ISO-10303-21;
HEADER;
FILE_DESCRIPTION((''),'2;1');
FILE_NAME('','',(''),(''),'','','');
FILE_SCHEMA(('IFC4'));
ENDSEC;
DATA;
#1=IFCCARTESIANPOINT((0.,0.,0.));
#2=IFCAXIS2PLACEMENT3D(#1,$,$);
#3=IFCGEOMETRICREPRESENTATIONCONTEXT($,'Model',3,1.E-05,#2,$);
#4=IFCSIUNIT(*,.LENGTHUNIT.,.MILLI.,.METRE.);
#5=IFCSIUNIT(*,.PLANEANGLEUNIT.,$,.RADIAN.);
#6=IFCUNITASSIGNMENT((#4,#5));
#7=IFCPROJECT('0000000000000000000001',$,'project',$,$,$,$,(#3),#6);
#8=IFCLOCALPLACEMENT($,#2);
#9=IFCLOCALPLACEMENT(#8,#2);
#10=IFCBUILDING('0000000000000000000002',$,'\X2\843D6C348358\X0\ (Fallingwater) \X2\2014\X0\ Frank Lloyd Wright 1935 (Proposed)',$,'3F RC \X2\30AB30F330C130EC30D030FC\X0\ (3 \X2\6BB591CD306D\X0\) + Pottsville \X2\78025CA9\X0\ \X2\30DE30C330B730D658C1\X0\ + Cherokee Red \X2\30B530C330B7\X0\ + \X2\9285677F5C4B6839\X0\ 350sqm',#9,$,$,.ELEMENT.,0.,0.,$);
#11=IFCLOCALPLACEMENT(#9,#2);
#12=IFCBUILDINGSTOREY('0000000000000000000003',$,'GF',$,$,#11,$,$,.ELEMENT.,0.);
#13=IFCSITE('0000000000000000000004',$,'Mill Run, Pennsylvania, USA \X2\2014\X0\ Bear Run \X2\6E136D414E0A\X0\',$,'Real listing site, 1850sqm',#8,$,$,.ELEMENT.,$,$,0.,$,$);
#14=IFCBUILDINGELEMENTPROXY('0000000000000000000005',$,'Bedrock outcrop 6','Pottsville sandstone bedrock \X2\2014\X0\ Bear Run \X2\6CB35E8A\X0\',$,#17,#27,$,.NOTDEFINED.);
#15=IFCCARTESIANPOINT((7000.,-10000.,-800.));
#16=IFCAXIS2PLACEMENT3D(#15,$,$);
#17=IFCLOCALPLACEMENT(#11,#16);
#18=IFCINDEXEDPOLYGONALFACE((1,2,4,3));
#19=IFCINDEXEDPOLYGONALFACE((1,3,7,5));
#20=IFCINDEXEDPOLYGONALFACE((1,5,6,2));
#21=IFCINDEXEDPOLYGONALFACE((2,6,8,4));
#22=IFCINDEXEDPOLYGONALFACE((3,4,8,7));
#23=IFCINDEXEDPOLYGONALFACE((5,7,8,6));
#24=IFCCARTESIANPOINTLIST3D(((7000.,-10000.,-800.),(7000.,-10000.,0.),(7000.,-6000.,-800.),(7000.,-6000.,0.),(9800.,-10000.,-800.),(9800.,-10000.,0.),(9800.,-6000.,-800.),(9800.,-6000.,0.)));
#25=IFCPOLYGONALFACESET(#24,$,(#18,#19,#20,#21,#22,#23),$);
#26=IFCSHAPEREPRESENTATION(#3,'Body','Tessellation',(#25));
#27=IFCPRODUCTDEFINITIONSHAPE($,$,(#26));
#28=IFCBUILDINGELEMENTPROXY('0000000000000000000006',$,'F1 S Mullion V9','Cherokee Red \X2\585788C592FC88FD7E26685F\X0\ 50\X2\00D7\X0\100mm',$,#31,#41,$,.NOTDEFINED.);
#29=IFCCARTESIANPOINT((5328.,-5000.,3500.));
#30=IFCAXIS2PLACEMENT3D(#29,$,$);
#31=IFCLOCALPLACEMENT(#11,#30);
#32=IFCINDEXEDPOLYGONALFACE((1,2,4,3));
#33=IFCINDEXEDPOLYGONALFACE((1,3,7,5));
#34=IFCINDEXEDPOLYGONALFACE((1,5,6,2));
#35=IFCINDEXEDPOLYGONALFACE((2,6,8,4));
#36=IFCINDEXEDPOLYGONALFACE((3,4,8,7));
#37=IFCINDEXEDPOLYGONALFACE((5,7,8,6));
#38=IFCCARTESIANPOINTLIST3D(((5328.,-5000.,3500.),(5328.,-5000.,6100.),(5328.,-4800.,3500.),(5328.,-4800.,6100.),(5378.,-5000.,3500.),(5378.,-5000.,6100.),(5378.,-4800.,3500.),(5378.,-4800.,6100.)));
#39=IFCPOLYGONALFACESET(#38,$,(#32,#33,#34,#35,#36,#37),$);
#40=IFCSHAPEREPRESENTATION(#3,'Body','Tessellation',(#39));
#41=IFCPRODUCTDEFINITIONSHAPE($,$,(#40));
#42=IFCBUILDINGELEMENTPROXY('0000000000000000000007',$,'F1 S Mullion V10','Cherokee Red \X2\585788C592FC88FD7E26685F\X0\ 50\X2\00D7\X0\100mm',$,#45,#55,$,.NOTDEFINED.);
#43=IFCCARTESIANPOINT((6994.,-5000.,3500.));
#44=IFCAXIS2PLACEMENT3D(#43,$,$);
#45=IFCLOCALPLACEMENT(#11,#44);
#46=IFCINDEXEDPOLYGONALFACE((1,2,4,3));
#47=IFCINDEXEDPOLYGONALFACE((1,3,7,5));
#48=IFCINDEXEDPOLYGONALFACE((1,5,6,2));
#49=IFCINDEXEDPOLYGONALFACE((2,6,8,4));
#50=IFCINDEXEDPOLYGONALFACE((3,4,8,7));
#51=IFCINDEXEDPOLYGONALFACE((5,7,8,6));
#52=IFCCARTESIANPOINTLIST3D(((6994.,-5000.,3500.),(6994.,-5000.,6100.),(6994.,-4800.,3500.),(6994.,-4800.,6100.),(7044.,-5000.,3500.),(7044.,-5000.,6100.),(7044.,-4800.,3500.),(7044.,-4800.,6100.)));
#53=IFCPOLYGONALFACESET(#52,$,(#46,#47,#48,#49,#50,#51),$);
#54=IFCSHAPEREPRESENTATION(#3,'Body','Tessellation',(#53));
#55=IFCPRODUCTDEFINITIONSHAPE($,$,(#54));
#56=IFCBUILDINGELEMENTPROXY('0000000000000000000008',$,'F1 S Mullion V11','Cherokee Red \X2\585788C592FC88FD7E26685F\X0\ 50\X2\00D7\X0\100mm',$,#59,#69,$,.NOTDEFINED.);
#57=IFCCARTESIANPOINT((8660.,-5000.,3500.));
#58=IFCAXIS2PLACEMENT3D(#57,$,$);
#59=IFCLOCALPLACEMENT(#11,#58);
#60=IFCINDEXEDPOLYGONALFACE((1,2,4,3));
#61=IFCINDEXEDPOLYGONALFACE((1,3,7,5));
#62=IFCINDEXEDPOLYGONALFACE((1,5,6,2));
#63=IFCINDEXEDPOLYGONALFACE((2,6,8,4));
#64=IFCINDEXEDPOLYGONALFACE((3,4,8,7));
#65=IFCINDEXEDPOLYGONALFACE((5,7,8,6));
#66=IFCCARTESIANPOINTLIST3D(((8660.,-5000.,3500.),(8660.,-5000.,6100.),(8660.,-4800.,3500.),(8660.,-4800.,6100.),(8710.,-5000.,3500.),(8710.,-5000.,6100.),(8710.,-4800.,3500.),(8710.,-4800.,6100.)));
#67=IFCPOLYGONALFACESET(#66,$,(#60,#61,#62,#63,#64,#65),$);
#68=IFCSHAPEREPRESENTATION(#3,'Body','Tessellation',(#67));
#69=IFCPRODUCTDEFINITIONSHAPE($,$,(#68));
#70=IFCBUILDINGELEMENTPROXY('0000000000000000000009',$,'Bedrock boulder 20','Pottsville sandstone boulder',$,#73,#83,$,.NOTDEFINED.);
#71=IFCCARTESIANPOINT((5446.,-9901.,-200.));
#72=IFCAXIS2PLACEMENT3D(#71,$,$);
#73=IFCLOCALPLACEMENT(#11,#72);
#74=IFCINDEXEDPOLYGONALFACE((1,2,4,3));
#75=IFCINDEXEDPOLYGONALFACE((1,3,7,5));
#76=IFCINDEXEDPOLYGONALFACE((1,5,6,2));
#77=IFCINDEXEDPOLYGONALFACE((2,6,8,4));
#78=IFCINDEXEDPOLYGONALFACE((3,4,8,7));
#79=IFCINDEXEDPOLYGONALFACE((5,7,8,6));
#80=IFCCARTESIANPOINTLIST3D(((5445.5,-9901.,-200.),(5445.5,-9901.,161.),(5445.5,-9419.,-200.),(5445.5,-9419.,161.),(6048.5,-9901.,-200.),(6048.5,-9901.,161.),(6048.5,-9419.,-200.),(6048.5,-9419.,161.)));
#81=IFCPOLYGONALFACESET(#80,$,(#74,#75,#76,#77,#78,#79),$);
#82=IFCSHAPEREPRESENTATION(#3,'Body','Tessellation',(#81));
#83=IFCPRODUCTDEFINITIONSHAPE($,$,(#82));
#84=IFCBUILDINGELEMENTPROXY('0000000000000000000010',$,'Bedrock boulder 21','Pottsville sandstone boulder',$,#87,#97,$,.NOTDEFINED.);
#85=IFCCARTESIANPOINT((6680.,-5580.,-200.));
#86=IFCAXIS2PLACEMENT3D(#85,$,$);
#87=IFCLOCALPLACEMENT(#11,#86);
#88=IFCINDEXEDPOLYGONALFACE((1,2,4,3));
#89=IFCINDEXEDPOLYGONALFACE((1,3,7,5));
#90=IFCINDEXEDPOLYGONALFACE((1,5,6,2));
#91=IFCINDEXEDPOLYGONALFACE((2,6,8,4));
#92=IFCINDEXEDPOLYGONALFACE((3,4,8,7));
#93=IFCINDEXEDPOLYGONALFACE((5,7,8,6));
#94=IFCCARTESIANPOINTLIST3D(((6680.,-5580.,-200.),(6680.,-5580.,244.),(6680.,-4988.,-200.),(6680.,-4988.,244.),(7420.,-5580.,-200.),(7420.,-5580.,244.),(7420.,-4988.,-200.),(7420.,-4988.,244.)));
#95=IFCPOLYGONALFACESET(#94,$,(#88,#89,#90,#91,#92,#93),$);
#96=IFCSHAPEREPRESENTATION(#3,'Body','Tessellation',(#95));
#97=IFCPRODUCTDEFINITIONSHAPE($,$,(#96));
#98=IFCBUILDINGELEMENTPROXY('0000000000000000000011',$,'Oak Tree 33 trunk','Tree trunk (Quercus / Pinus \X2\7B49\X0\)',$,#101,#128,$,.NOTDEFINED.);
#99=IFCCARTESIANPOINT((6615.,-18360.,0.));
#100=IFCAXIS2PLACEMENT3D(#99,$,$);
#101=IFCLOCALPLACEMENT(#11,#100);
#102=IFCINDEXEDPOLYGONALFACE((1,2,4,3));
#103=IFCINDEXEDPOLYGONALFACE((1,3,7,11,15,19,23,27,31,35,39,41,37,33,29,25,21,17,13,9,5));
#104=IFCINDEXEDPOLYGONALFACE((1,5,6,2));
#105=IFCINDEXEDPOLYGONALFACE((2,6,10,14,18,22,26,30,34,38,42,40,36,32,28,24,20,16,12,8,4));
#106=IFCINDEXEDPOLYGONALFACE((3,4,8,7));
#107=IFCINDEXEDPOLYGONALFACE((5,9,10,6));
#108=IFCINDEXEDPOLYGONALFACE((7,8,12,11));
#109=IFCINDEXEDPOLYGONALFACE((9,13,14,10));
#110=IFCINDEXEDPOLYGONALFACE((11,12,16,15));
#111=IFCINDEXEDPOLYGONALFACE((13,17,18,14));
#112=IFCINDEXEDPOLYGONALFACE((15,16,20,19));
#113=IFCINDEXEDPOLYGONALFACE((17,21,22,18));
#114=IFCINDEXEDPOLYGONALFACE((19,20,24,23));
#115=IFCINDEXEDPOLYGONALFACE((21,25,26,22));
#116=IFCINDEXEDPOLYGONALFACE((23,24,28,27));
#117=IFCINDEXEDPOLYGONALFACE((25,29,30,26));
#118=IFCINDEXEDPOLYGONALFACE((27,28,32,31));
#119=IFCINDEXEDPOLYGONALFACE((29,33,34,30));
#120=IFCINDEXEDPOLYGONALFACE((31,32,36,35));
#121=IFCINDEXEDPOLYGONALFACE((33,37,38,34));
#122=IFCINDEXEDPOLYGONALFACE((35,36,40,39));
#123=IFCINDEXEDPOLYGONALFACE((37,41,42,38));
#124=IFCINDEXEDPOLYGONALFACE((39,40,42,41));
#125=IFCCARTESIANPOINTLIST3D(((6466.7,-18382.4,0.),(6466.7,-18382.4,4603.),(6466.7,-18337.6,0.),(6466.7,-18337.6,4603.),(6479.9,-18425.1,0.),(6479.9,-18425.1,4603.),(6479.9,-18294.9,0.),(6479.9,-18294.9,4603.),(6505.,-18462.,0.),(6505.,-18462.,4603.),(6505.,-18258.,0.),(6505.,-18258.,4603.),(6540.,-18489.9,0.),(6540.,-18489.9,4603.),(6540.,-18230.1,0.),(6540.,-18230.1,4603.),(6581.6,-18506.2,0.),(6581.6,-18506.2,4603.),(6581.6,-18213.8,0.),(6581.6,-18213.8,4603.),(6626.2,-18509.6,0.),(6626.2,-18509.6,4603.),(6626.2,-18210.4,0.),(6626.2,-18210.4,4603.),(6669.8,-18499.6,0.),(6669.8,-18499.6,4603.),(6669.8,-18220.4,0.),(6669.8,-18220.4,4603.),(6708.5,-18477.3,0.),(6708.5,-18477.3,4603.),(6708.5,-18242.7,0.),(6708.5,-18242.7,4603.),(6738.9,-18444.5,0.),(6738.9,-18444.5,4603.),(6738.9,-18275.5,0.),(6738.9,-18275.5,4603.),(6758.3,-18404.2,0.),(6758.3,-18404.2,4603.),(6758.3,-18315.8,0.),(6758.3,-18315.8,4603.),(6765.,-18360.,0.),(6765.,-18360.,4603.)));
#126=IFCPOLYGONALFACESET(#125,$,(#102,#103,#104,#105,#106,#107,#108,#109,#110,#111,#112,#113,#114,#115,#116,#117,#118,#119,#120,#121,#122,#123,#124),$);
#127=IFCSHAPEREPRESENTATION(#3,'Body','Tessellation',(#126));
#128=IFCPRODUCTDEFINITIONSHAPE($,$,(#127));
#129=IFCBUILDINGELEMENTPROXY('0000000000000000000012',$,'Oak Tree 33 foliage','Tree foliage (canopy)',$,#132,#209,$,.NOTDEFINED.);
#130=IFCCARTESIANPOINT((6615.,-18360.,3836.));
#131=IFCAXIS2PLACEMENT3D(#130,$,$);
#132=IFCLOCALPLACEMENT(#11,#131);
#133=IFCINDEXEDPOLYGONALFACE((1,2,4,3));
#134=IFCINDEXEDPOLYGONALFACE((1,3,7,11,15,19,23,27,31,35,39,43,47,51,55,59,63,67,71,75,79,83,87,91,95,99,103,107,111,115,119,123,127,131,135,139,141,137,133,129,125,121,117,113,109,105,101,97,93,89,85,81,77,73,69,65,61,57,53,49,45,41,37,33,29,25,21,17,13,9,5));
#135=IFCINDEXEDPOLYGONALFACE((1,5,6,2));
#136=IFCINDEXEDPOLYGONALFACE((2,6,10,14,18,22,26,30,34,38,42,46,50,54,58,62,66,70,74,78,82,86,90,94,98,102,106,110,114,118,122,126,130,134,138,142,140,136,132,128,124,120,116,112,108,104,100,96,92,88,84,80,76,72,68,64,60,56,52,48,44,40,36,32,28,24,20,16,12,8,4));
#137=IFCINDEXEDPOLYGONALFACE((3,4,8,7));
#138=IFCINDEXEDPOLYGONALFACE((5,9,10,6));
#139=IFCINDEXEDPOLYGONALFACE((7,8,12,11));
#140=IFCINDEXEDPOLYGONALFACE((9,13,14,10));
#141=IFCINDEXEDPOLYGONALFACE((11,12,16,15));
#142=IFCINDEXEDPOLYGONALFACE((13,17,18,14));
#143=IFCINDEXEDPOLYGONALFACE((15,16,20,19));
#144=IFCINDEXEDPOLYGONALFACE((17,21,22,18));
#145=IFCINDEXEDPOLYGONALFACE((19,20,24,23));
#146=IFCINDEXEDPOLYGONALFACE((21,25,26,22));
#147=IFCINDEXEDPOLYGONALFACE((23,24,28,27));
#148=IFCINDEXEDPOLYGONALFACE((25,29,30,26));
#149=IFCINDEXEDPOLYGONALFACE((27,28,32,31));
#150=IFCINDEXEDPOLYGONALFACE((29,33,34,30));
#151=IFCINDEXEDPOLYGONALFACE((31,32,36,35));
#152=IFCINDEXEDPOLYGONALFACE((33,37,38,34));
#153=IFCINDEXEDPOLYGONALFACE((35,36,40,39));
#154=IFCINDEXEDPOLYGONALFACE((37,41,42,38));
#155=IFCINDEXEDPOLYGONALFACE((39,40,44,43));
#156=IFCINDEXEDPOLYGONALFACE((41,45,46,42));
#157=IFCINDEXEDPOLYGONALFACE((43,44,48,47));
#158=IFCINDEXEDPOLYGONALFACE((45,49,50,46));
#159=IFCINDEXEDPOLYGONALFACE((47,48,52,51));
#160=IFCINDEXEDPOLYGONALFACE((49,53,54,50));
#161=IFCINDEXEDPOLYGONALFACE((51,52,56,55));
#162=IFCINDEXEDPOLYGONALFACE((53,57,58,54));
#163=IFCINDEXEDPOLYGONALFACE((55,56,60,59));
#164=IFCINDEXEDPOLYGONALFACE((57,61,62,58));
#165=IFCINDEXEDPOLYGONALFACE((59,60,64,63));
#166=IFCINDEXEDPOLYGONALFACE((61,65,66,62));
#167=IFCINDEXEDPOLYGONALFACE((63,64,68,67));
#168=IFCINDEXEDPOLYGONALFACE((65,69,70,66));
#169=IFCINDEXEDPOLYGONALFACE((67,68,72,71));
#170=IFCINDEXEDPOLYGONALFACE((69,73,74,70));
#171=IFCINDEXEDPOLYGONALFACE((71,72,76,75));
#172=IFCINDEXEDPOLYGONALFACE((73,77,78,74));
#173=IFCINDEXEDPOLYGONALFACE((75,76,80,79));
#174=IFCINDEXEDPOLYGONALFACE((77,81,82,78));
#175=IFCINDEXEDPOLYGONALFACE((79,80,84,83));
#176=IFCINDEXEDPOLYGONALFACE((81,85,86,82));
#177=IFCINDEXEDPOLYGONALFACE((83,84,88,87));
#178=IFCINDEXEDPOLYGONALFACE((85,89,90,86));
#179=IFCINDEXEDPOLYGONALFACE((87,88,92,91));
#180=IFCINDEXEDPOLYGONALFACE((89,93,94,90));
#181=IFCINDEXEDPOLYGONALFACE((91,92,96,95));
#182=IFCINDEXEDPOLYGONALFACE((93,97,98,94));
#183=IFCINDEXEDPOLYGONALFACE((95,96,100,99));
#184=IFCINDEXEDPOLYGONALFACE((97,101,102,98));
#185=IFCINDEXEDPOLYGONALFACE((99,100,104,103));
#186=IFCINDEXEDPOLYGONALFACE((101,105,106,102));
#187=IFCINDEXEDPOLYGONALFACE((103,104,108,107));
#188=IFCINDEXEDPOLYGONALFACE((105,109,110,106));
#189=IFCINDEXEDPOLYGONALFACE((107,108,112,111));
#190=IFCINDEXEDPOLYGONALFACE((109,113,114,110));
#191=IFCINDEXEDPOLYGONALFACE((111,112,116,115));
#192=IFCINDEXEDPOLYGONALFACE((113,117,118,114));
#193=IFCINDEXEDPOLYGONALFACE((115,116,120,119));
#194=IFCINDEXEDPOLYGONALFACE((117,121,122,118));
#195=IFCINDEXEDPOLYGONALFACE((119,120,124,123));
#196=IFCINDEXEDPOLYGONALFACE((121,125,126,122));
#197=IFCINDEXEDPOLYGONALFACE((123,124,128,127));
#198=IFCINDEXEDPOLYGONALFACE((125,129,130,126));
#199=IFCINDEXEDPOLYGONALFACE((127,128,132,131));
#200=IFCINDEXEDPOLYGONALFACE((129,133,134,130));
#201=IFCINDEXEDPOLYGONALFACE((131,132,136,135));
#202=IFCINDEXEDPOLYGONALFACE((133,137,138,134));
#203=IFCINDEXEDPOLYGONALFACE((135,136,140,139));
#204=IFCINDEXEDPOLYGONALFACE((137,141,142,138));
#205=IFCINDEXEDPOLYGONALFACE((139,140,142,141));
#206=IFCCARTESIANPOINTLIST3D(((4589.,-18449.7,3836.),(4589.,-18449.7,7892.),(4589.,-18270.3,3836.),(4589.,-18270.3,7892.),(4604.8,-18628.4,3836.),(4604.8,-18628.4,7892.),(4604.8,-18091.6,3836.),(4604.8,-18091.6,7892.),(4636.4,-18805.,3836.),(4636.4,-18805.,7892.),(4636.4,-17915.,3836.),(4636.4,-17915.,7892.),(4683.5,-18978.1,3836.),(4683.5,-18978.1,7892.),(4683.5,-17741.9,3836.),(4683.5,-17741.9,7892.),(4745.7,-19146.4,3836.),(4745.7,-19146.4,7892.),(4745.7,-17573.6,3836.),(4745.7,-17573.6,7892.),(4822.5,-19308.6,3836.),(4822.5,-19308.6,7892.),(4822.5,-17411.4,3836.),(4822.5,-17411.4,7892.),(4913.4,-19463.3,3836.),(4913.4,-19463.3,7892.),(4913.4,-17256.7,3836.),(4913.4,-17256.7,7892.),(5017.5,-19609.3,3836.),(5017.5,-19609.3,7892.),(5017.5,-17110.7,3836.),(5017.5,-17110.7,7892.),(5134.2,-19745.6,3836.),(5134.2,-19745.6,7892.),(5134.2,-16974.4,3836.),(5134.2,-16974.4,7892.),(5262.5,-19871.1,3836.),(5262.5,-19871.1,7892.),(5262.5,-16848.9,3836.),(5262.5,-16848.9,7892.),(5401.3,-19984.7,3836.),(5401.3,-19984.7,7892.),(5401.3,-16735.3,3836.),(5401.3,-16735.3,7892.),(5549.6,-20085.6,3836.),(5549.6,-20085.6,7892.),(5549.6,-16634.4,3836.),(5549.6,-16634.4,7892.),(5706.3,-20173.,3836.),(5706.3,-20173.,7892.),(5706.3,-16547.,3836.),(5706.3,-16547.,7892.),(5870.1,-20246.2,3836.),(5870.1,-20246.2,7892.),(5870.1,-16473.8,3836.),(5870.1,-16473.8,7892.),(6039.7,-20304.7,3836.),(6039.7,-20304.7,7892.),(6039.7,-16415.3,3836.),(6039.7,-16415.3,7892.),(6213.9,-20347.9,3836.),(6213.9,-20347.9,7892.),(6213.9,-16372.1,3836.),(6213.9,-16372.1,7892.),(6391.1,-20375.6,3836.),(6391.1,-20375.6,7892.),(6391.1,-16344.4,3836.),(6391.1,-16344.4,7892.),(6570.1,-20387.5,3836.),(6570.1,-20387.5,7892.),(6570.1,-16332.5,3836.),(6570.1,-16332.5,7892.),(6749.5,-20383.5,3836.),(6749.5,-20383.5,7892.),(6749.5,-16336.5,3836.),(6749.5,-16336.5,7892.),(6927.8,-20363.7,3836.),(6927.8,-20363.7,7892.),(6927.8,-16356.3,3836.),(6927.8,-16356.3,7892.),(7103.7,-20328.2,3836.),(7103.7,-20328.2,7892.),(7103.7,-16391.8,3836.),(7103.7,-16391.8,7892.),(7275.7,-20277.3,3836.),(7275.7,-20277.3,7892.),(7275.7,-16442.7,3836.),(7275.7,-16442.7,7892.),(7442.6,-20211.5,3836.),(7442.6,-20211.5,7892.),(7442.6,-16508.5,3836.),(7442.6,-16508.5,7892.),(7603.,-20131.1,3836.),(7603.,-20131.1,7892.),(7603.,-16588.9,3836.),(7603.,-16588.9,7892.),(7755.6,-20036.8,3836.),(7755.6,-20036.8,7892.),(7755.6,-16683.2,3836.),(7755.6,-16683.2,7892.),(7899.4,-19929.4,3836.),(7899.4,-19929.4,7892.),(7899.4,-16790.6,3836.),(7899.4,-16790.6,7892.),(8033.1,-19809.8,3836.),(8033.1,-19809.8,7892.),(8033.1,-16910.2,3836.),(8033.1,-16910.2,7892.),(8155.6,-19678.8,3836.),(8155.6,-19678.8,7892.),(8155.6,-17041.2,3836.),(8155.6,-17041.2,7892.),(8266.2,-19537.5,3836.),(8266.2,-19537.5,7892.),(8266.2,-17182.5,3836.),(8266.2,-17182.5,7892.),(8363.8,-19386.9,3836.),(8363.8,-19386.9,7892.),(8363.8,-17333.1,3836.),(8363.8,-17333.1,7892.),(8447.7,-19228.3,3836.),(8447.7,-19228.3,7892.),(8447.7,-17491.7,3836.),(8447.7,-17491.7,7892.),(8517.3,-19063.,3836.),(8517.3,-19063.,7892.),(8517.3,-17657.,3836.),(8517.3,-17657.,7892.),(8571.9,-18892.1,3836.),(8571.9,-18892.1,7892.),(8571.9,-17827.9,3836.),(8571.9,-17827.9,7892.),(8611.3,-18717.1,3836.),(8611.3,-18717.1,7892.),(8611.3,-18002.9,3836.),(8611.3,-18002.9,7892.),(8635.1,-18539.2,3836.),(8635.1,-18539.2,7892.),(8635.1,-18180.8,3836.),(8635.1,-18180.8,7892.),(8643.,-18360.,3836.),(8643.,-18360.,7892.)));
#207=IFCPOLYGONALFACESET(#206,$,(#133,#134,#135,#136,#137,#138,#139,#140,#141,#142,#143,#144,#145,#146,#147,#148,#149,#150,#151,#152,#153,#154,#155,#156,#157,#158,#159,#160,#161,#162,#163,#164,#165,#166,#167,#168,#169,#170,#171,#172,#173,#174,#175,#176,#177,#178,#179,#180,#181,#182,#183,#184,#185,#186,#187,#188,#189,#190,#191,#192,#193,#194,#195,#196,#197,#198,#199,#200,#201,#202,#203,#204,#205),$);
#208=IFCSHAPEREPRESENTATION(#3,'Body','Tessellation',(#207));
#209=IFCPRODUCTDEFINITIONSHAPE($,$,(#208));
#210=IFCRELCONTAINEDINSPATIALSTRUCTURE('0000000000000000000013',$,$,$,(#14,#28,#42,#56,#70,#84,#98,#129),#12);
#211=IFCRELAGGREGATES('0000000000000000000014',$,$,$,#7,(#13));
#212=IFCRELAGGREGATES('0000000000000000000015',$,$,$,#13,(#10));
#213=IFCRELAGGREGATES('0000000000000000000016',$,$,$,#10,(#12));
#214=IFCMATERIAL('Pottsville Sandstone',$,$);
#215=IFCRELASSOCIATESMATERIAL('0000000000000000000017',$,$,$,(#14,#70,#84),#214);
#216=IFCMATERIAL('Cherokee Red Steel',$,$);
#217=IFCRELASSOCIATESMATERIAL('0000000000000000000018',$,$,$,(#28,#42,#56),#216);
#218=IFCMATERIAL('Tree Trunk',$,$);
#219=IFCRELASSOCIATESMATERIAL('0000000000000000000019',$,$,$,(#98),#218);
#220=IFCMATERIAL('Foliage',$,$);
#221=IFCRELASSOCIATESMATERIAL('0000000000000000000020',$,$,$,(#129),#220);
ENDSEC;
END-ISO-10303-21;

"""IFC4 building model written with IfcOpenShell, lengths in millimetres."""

from ifc_helpers import new_model, si_unit, frame, frame_2d, origin, origin_2d, place, context, project, spatial, rectangle, circle, extrude, material, element, save


model = new_model("IFC4")

# Units and contexts
model_context = context("Model", 3, precision=1e-05, world=origin())
ifc_project = project(units=[si_unit("LENGTHUNIT", "METRE", prefix="MILLI"), si_unit("PLANEANGLEUNIT", "RADIAN")], contexts=[model_context])

# Site, building, storey
site_placement = place(None, origin())
site = spatial("IfcSite", under=ifc_project, at=site_placement, Name="Mill Run, Pennsylvania, USA — Bear Run 渓流上", ObjectType="Real listing site, 1850sqm", CompositionType="ELEMENT", RefElevation=0.0)
building_placement = place(site_placement, origin())
building = spatial("IfcBuilding", under=site, at=building_placement, Name="落水荘 (Fallingwater) — Frank Lloyd Wright 1935 (Proposed)", ObjectType="3F RC カンチレバー (3 段重ね) + Pottsville 砂岩 マッシブ壁 + Cherokee Red サッシ + 銅板屋根 350sqm", CompositionType="ELEMENT", ElevationOfRefHeight=0.0, ElevationOfTerrain=0.0)
storey_placement = place(building_placement, origin())
storey = spatial("IfcBuildingStorey", under=building, at=storey_placement, Name="GF", CompositionType="ELEMENT", Elevation=0.0)

# Shared definitions
ifc_material_1 = material(Name="Cherokee Red Steel")

# Building element proxies
ifc_material_2 = material(Name="Pottsville Sandstone")
proxy_1_placement = place(storey_placement, frame((7000.0, -10000.0, -800.0)))
element("IfcBuildingElementProxy", 1, at=proxy_1_placement, inside=storey, material=ifc_material_2, Name="Bedrock outcrop 6", Description="Pottsville sandstone bedrock — Bear Run 河床", PredefinedType="NOTDEFINED", context=model_context, shape_type="SweptSolid", body=[
    extrude(rectangle(XDim=2800.0, YDim=4000.0, at=frame_2d((1400.0, 2000.0))), frame((7000.0, -10000.0, -800.0)), (0.0, 0.0, 1.0), 800.0),
])
proxy_2_placement = place(storey_placement, frame((5328.0, -5000.0, 3500.0)))
element("IfcBuildingElementProxy", 2, at=proxy_2_placement, inside=storey, material=ifc_material_1, Name="F1 S Mullion V9", Description="Cherokee Red 塗装鋼製縦桟 50×100mm", PredefinedType="NOTDEFINED", context=model_context, shape_type="SweptSolid", body=[
    extrude(rectangle(XDim=50.0, YDim=200.0, at=frame_2d((25.0, 100.0))), frame((5328.0, -5000.0, 3500.0)), (0.0, 0.0, 1.0), 2600.0),
])
proxy_3_placement = place(storey_placement, frame((6994.0, -5000.0, 3500.0)))
element("IfcBuildingElementProxy", 3, at=proxy_3_placement, inside=storey, material=ifc_material_1, Name="F1 S Mullion V10", Description="Cherokee Red 塗装鋼製縦桟 50×100mm", PredefinedType="NOTDEFINED", context=model_context, shape_type="SweptSolid", body=[
    extrude(rectangle(XDim=50.0, YDim=200.0, at=frame_2d((25.0, 100.0))), frame((6994.0, -5000.0, 3500.0)), (0.0, 0.0, 1.0), 2600.0),
])
proxy_4_placement = place(storey_placement, frame((8660.0, -5000.0, 3500.0)))
element("IfcBuildingElementProxy", 4, at=proxy_4_placement, inside=storey, material=ifc_material_1, Name="F1 S Mullion V11", Description="Cherokee Red 塗装鋼製縦桟 50×100mm", PredefinedType="NOTDEFINED", context=model_context, shape_type="SweptSolid", body=[
    extrude(rectangle(XDim=50.0, YDim=200.0, at=frame_2d((25.0, 100.0))), frame((8660.0, -5000.0, 3500.0)), (0.0, 0.0, 1.0), 2600.0),
])
proxy_5_placement = place(storey_placement, frame((5446.0, -9901.0, -200.0)))
element("IfcBuildingElementProxy", 5, at=proxy_5_placement, inside=storey, material=ifc_material_2, Name="Bedrock boulder 20", Description="Pottsville sandstone boulder", PredefinedType="NOTDEFINED", context=model_context, shape_type="SweptSolid", body=[
    extrude(rectangle(XDim=603.0, YDim=482.0, at=frame_2d((301.0, 241.0))), frame((5446.0, -9901.0, -200.0)), (0.0, 0.0, 1.0), 361.0),
])
proxy_6_placement = place(storey_placement, frame((6680.0, -5580.0, -200.0)))
element("IfcBuildingElementProxy", 6, at=proxy_6_placement, inside=storey, material=ifc_material_2, Name="Bedrock boulder 21", Description="Pottsville sandstone boulder", PredefinedType="NOTDEFINED", context=model_context, shape_type="SweptSolid", body=[
    extrude(rectangle(XDim=740.0, YDim=592.0, at=frame_2d((370.0, 296.0))), frame((6680.0, -5580.0, -200.0)), (0.0, 0.0, 1.0), 444.0),
])
ifc_material_3 = material(Name="Tree Trunk")
proxy_7_placement = place(storey_placement, frame((6615.0, -18360.0, 0.0)))
element("IfcBuildingElementProxy", 7, at=proxy_7_placement, inside=storey, material=ifc_material_3, Name="Oak Tree 33 trunk", Description="Tree trunk (Quercus / Pinus 等)", PredefinedType="NOTDEFINED", context=model_context, shape_type="SweptSolid", body=[
    extrude(circle(Radius=150.0, at=origin_2d()), frame((6615.0, -18360.0, 0.0)), (0.0, 0.0, 1.0), 4603.0),
])
ifc_material_4 = material(Name="Foliage")
proxy_8_placement = place(storey_placement, frame((6615.0, -18360.0, 3836.0)))
element("IfcBuildingElementProxy", 8, at=proxy_8_placement, inside=storey, material=ifc_material_4, Name="Oak Tree 33 foliage", Description="Tree foliage (canopy)", PredefinedType="NOTDEFINED", context=model_context, shape_type="SweptSolid", body=[
    extrude(circle(Radius=2028.0, at=origin_2d()), frame((6615.0, -18360.0, 3836.0)), (0.0, 0.0, 1.0), 4056.0),
])

save(model, "model.ifc")
